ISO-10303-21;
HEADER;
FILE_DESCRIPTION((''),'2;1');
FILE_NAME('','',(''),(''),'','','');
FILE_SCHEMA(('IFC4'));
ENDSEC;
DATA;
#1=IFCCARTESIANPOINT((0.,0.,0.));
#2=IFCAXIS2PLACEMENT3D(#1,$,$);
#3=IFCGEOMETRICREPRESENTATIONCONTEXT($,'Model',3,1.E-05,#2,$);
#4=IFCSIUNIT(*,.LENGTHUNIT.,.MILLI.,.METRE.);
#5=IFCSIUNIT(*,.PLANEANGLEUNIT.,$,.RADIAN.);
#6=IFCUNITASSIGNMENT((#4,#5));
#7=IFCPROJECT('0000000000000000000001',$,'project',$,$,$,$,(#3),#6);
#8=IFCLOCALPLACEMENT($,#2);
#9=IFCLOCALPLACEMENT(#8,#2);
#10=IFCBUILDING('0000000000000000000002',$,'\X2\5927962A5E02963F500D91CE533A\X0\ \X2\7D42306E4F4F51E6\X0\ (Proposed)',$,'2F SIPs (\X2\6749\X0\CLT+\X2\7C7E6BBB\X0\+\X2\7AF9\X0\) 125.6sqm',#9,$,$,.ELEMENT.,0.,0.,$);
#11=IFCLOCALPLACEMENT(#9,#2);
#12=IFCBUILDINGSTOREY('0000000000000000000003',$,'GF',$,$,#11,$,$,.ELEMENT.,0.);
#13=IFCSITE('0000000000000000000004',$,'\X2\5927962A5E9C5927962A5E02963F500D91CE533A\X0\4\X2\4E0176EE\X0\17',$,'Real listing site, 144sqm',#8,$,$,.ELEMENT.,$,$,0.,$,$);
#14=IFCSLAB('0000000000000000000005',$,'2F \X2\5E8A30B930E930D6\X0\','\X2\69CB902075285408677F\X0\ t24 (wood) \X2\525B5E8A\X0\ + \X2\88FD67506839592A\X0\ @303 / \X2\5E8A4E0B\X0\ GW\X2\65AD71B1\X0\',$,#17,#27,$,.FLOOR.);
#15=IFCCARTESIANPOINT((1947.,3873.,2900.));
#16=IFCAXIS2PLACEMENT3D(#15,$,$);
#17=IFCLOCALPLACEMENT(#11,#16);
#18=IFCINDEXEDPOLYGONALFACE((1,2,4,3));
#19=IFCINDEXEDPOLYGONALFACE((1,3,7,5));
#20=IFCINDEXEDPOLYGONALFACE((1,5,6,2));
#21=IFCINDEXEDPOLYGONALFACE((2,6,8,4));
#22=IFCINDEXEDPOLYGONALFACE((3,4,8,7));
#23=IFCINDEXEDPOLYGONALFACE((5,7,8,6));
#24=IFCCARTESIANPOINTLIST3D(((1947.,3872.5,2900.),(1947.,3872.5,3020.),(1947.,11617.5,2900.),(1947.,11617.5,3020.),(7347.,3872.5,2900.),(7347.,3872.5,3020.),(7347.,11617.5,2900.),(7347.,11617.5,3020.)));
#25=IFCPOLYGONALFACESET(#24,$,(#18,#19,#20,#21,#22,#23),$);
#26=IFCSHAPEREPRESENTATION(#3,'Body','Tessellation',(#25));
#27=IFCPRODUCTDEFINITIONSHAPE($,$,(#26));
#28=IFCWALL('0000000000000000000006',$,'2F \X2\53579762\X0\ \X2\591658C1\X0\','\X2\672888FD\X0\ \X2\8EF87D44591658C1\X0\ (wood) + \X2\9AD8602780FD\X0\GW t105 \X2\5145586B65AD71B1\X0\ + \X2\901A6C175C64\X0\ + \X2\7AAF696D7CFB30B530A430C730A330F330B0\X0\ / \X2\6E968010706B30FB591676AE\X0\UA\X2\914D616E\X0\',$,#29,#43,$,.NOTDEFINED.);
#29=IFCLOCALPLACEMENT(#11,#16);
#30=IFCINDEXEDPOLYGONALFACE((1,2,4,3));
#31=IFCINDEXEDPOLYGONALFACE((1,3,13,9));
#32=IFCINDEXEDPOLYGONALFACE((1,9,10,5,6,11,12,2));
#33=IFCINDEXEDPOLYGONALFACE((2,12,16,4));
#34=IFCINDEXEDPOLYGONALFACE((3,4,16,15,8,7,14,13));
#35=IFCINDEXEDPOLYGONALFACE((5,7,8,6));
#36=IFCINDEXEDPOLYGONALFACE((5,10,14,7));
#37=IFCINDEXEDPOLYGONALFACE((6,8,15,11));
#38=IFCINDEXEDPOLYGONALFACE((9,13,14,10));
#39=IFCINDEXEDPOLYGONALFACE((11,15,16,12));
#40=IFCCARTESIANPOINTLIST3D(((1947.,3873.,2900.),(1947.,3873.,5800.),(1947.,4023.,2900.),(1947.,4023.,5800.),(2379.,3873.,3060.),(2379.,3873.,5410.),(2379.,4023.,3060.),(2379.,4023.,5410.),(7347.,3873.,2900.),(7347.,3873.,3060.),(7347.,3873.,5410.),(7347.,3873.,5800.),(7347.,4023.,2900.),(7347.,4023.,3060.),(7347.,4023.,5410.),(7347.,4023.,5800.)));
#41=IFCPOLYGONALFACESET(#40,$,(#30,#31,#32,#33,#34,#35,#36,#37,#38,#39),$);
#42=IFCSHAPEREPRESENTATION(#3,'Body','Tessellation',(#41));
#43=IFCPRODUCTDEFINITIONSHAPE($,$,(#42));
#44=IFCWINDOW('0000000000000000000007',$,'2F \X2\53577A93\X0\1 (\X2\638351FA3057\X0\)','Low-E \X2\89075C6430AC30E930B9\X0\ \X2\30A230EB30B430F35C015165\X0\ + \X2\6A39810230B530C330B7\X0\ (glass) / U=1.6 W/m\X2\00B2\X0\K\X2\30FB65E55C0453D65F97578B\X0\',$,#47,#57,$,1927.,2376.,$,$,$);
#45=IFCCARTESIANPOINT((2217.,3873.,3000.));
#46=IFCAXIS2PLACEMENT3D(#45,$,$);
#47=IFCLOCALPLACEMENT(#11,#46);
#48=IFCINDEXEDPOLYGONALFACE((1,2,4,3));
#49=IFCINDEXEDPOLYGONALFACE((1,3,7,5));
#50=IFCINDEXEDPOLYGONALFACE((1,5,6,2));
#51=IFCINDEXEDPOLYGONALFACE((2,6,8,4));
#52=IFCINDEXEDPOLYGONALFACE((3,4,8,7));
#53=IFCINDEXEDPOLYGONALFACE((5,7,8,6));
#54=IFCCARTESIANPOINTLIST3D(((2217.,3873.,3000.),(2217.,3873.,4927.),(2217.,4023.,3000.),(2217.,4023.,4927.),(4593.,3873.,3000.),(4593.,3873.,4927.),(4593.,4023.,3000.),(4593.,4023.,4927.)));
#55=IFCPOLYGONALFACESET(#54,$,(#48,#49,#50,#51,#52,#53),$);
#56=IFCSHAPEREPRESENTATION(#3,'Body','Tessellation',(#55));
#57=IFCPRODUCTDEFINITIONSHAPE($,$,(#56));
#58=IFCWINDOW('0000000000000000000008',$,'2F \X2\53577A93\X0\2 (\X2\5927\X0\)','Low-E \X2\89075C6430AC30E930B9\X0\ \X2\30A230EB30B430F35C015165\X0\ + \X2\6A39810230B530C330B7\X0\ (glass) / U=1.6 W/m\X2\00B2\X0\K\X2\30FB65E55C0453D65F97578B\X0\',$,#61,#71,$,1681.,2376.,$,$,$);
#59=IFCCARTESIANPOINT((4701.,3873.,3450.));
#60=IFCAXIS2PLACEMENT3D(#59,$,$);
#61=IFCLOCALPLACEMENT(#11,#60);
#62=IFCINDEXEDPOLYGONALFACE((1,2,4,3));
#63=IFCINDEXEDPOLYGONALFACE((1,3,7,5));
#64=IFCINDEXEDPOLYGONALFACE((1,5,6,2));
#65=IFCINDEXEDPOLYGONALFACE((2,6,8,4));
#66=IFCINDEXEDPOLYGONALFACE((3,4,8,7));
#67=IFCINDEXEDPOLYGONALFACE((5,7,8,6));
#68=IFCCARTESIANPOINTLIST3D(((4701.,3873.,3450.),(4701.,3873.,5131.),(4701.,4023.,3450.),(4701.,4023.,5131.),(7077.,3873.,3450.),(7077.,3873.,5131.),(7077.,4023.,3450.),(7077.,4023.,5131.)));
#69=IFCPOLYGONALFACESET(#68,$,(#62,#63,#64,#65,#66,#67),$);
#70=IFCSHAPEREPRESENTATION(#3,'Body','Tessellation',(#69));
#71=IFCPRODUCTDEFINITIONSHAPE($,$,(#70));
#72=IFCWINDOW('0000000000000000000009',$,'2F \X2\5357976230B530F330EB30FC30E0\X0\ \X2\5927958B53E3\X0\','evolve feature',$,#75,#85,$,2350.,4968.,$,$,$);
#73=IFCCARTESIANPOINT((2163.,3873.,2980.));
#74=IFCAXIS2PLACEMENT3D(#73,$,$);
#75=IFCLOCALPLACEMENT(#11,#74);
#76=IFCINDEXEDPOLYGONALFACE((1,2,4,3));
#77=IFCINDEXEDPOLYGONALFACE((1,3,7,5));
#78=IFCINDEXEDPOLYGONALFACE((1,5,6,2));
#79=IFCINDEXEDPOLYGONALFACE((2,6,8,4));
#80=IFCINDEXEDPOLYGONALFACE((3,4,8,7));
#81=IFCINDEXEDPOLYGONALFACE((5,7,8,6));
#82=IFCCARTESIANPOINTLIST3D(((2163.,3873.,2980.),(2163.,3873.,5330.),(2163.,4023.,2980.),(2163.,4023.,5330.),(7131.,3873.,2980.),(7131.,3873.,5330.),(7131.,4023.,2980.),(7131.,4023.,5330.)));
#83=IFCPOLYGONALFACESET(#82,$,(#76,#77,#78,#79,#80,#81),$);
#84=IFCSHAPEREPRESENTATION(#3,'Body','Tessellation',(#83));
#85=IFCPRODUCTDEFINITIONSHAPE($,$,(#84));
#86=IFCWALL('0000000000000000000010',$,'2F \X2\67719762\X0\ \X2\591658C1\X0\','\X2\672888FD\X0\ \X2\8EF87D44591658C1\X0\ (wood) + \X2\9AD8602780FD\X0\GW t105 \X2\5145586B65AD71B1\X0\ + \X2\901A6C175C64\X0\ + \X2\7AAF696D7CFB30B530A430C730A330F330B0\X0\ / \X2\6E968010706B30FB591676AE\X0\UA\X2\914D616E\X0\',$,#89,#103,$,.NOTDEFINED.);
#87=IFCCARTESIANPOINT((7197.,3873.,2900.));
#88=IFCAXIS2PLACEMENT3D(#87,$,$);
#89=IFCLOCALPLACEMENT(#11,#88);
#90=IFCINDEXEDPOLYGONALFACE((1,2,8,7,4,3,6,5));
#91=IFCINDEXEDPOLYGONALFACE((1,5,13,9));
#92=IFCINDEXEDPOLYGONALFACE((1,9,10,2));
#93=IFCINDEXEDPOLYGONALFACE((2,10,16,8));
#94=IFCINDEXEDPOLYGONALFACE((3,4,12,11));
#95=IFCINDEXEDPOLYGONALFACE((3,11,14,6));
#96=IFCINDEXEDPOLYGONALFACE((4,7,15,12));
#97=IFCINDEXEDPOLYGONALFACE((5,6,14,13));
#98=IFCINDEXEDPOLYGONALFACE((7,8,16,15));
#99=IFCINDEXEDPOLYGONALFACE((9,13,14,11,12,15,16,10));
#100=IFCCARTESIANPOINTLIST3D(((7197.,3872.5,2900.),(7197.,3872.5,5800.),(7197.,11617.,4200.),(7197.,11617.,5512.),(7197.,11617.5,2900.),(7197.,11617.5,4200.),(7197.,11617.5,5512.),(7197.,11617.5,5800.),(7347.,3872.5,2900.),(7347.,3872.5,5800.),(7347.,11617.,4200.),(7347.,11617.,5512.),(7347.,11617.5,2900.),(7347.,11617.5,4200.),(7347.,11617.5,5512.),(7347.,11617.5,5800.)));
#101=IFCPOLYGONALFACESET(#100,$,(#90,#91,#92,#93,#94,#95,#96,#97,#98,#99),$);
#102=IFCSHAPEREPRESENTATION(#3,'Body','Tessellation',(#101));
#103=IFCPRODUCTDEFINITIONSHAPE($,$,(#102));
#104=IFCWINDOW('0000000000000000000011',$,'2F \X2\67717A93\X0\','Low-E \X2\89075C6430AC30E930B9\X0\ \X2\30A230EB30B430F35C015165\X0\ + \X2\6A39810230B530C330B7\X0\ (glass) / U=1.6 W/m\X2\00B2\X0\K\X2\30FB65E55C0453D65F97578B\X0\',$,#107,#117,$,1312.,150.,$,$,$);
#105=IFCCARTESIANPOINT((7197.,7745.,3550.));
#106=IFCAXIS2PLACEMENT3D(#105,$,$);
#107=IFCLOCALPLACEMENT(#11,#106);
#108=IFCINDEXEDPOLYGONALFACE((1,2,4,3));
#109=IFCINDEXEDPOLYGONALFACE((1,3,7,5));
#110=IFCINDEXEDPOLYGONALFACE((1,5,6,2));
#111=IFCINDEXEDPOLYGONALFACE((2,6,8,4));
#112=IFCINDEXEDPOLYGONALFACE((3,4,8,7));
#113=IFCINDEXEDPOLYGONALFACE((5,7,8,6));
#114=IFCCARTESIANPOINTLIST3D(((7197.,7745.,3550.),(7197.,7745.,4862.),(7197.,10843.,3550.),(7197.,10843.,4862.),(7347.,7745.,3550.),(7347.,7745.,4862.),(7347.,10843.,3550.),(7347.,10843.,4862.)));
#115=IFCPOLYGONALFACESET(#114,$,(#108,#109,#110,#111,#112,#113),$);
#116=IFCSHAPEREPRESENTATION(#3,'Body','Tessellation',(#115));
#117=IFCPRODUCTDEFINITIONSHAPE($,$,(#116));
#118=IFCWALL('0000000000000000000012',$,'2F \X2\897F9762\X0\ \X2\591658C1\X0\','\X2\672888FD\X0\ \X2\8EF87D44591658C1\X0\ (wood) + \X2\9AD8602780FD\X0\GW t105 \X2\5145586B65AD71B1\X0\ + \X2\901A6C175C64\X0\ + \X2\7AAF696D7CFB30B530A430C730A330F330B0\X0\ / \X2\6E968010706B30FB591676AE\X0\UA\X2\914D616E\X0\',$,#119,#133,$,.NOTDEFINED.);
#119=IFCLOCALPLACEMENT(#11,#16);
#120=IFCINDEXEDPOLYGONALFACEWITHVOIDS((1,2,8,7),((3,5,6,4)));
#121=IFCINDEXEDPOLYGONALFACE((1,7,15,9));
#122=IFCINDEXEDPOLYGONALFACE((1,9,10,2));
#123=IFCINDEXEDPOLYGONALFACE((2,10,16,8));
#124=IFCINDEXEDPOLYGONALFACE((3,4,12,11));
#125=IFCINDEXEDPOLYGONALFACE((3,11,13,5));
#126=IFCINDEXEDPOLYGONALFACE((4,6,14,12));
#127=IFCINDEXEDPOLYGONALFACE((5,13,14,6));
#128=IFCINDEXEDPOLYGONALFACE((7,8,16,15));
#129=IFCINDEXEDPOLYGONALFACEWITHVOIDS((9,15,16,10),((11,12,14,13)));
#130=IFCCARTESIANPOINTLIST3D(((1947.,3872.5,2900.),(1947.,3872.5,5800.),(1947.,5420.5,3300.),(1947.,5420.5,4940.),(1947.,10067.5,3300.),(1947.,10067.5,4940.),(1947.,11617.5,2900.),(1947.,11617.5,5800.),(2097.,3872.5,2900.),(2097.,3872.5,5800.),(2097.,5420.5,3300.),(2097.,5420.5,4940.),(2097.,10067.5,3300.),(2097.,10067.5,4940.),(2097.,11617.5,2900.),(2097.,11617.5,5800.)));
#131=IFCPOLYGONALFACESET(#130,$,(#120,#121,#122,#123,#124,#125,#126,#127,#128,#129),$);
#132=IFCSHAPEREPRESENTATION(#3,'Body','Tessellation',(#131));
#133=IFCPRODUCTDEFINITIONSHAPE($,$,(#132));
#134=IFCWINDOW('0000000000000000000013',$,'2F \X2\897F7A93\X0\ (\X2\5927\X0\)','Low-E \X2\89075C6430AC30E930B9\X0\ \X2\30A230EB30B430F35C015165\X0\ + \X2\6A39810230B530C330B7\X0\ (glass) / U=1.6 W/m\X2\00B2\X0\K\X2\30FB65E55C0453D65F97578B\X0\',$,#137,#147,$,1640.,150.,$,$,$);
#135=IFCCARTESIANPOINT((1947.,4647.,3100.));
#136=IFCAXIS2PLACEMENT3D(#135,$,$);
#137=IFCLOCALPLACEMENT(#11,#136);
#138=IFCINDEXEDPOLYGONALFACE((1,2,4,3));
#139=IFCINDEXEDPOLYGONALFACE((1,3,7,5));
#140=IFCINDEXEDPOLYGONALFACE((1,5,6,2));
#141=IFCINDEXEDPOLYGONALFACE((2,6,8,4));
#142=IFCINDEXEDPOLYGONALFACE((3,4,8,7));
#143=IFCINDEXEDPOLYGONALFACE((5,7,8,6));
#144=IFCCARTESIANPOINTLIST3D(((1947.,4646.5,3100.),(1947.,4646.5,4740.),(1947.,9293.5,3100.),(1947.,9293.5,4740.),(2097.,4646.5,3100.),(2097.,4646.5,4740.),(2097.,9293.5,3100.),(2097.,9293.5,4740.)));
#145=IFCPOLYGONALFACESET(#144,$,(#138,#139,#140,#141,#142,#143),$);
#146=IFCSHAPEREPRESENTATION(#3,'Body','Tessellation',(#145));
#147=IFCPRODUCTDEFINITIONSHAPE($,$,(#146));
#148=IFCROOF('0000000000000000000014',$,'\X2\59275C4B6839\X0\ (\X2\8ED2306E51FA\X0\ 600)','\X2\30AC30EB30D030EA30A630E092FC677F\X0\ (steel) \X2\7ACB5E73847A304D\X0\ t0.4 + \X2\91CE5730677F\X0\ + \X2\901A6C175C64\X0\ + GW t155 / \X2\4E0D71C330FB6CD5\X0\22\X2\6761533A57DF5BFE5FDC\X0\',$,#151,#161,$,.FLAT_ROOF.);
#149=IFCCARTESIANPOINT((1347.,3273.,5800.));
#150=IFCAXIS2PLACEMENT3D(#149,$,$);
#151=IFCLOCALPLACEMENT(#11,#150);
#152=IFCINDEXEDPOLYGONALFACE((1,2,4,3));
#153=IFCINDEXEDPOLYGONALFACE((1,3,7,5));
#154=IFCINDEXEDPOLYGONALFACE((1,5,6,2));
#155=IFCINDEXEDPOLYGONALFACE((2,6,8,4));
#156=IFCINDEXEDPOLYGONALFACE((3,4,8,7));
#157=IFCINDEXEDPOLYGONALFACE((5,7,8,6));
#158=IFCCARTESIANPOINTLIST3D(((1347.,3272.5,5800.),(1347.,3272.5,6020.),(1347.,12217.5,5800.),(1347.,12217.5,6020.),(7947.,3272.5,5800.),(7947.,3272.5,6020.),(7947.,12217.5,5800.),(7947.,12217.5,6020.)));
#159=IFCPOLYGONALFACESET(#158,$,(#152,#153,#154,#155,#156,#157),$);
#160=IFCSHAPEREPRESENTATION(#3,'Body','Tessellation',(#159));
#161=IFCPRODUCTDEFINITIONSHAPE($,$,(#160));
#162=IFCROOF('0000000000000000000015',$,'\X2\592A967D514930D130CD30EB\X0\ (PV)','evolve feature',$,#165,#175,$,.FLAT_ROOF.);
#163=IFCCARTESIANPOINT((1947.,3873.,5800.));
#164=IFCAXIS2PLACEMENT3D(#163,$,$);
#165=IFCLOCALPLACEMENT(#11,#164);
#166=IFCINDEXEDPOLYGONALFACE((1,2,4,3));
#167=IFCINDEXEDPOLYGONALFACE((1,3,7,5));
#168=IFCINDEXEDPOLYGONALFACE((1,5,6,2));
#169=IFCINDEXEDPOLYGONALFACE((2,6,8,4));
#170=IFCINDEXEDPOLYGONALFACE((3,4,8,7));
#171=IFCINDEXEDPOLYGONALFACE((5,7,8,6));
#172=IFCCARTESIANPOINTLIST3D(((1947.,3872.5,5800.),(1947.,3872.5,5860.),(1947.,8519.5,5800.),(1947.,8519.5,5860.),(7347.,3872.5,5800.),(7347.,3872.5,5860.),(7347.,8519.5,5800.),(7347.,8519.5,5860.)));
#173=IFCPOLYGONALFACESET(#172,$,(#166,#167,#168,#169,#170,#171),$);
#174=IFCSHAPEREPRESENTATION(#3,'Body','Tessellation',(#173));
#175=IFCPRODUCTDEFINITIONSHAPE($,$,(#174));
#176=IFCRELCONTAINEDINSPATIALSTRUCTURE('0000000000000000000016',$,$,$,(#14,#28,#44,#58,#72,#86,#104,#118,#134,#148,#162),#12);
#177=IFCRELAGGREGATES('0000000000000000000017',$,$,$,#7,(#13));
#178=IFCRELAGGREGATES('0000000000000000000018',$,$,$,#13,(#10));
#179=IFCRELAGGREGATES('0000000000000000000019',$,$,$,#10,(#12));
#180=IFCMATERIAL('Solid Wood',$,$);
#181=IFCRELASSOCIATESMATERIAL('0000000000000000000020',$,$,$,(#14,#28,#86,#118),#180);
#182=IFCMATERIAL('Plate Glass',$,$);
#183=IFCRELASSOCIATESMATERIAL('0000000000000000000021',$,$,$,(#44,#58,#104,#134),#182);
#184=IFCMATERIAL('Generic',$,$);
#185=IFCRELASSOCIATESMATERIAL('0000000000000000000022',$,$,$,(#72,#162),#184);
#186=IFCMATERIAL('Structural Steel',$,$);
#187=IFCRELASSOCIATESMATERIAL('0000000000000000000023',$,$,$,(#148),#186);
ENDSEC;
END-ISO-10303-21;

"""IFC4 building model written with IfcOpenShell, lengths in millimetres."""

from ifc_helpers import new_model, si_unit, frame, frame_2d, origin, place, context, project, spatial, rectangle, extrude, material, element, fill, save


model = new_model("IFC4")

# Units and contexts
model_context = context("Model", 3, precision=1e-05, world=origin())
ifc_project = project(units=[si_unit("LENGTHUNIT", "METRE", prefix="MILLI"), si_unit("PLANEANGLEUNIT", "RADIAN")], contexts=[model_context])

# Site, building, storey
site_placement = place(None, origin())
site = spatial("IfcSite", under=ifc_project, at=site_placement, Name="大阪府大阪市阿倍野区4丁目17", ObjectType="Real listing site, 144sqm", CompositionType="ELEMENT", RefElevation=0.0)
building_placement = place(site_placement, origin())
building = spatial("IfcBuilding", under=site, at=building_placement, Name="大阪市阿倍野区 終の住処 (Proposed)", ObjectType="2F SIPs (杉CLT+籾殻+竹) 125.6sqm", CompositionType="ELEMENT", ElevationOfRefHeight=0.0, ElevationOfTerrain=0.0)
storey_placement = place(building_placement, origin())
storey = spatial("IfcBuildingStorey", under=building, at=storey_placement, Name="GF", CompositionType="ELEMENT", Elevation=0.0)

# Slab
ifc_material_1 = material(Name="Solid Wood")
slab_placement = place(storey_placement, frame((1947.0, 3873.0, 2900.0)))
element("IfcSlab", 1, at=slab_placement, inside=storey, material=ifc_material_1, Name="2F 床スラブ", Description="構造用合板 t24 (wood) 剛床 + 製材根太 @303 / 床下 GW断熱", PredefinedType="FLOOR", context=model_context, shape_type="SweptSolid", body=[
    extrude(rectangle(XDim=5400.0, YDim=7745.0, at=frame_2d((2700.0, 3872.0))), frame((1947.0, 3873.0, 2900.0)), (0.0, 0.0, 1.0), 120.0),
])

# Wall, openings, windows
wall_1_placement = place(storey_placement, frame((1947.0, 3873.0, 2900.0)))
wall_1 = element("IfcWall", 2, at=wall_1_placement, inside=storey, material=ifc_material_1, Name="2F 南面 外壁", Description="木製 軸組外壁 (wood) + 高性能GW t105 充填断熱 + 通気層 + 窯業系サイディング / 準耐火・外皮UA配慮", PredefinedType="NOTDEFINED", context=model_context, shape_type="SweptSolid", body=[
    extrude(rectangle(XDim=5400.0, YDim=150.0, at=frame_2d((2700.0, 75.0))), frame((1947.0, 3873.0, 2900.0)), (0.0, 0.0, 1.0), 2900.0),
])
opening_1_placement = place(storey_placement, frame((2217.0, 3873.0, 3000.0)))
opening_1 = element("IfcOpeningElement", 3, at=opening_1_placement, cuts=wall_1, PredefinedType="NOTDEFINED", context=model_context, shape_type="SweptSolid", body=[
    extrude(rectangle(XDim=2376.0, YDim=150.0, at=frame_2d((1188.0, 75.0))), frame((2217.0, 3873.0, 3000.0)), (0.0, 0.0, 1.0), 1927.0),
])
opening_2_placement = place(storey_placement, frame((4701.0, 3873.0, 3450.0)))
opening_2 = element("IfcOpeningElement", 4, at=opening_2_placement, cuts=wall_1, PredefinedType="NOTDEFINED", context=model_context, shape_type="SweptSolid", body=[
    extrude(rectangle(XDim=2376.0, YDim=150.0, at=frame_2d((1188.0, 75.0))), frame((4701.0, 3873.0, 3450.0)), (0.0, 0.0, 1.0), 1681.0),
])
opening_3_placement = place(storey_placement, frame((2163.0, 3873.0, 2980.0)))
opening_3 = element("IfcOpeningElement", 5, at=opening_3_placement, cuts=wall_1, PredefinedType="NOTDEFINED", context=model_context, shape_type="SweptSolid", body=[
    extrude(rectangle(XDim=4968.0, YDim=150.0, at=frame_2d((2484.0, 75.0))), frame((2163.0, 3873.0, 2980.0)), (0.0, 0.0, 1.0), 2350.0),
])
ifc_material_2 = material(Name="Plate Glass")
window_1_placement = place(storey_placement, frame((2217.0, 3873.0, 3000.0)))
window_1 = element("IfcWindow", 6, at=window_1_placement, inside=storey, material=ifc_material_2, Name="2F 南窓1 (掃出し)", Description="Low-E 複層ガラス アルゴン封入 + 樹脂サッシ (glass) / U=1.6 W/m²K・日射取得型", OverallHeight=1927.0, OverallWidth=2376.0, context=model_context, shape_type="SweptSolid", body=[
    extrude(rectangle(XDim=2376.0, YDim=150.0, at=frame_2d((1188.0, 75.0))), frame((2217.0, 3873.0, 3000.0)), (0.0, 0.0, 1.0), 1927.0),
])
fill(opening_1, window_1)
window_2_placement = place(storey_placement, frame((4701.0, 3873.0, 3450.0)))
window_2 = element("IfcWindow", 7, at=window_2_placement, inside=storey, material=ifc_material_2, Name="2F 南窓2 (大)", Description="Low-E 複層ガラス アルゴン封入 + 樹脂サッシ (glass) / U=1.6 W/m²K・日射取得型", OverallHeight=1681.0, OverallWidth=2376.0, context=model_context, shape_type="SweptSolid", body=[
    extrude(rectangle(XDim=2376.0, YDim=150.0, at=frame_2d((1188.0, 75.0))), frame((4701.0, 3873.0, 3450.0)), (0.0, 0.0, 1.0), 1681.0),
])
fill(opening_2, window_2)
ifc_material_3 = material(Name="Generic")
window_3_placement = place(storey_placement, frame((2163.0, 3873.0, 2980.0)))
window_3 = element("IfcWindow", 8, at=window_3_placement, inside=storey, material=ifc_material_3, Name="2F 南面サンルーム 大開口", Description="evolve feature", OverallHeight=2350.0, OverallWidth=4968.0, context=model_context, shape_type="SweptSolid", body=[
    extrude(rectangle(XDim=4968.0, YDim=150.0, at=frame_2d((2484.0, 75.0))), frame((2163.0, 3873.0, 2980.0)), (0.0, 0.0, 1.0), 2350.0),
])
fill(opening_3, window_3)

# Walls, openings, windows
wall_2_placement = place(storey_placement, frame((7197.0, 3873.0, 2900.0)))
wall_2 = element("IfcWall", 9, at=wall_2_placement, inside=storey, material=ifc_material_1, Name="2F 東面 外壁", Description="木製 軸組外壁 (wood) + 高性能GW t105 充填断熱 + 通気層 + 窯業系サイディング / 準耐火・外皮UA配慮", PredefinedType="NOTDEFINED", context=model_context, shape_type="SweptSolid", body=[
    extrude(rectangle(XDim=150.0, YDim=7745.0, at=frame_2d((75.0, 3872.0))), frame((7197.0, 3873.0, 2900.0)), (0.0, 0.0, 1.0), 2900.0),
])
opening_4_placement = place(storey_placement, frame((7197.0, 7745.0, 3550.0)))
opening_4 = element("IfcOpeningElement", 10, at=opening_4_placement, cuts=wall_2, PredefinedType="NOTDEFINED", context=model_context, shape_type="SweptSolid", body=[
    extrude(rectangle(XDim=150.0, YDim=3098.0, at=frame_2d((75.0, 1549.0))), frame((7197.0, 7745.0, 3550.0)), (0.0, 0.0, 1.0), 1312.0),
])
window_4_placement = place(storey_placement, frame((7197.0, 7745.0, 3550.0)))
window_4 = element("IfcWindow", 11, at=window_4_placement, inside=storey, material=ifc_material_2, Name="2F 東窓", Description="Low-E 複層ガラス アルゴン封入 + 樹脂サッシ (glass) / U=1.6 W/m²K・日射取得型", OverallHeight=1312.0, OverallWidth=150.0, context=model_context, shape_type="SweptSolid", body=[
    extrude(rectangle(XDim=150.0, YDim=3098.0, at=frame_2d((75.0, 1549.0))), frame((7197.0, 7745.0, 3550.0)), (0.0, 0.0, 1.0), 1312.0),
])
fill(opening_4, window_4)
wall_3_placement = place(storey_placement, frame((1947.0, 3873.0, 2900.0)))
wall_3 = element("IfcWall", 12, at=wall_3_placement, inside=storey, material=ifc_material_1, Name="2F 西面 外壁", Description="木製 軸組外壁 (wood) + 高性能GW t105 充填断熱 + 通気層 + 窯業系サイディング / 準耐火・外皮UA配慮", PredefinedType="NOTDEFINED", context=model_context, shape_type="SweptSolid", body=[
    extrude(rectangle(XDim=150.0, YDim=7745.0, at=frame_2d((75.0, 3872.0))), frame((1947.0, 3873.0, 2900.0)), (0.0, 0.0, 1.0), 2900.0),
])
opening_5_placement = place(storey_placement, frame((1947.0, 4647.0, 3100.0)))
opening_5 = element("IfcOpeningElement", 13, at=opening_5_placement, cuts=wall_3, PredefinedType="NOTDEFINED", context=model_context, shape_type="SweptSolid", body=[
    extrude(rectangle(XDim=150.0, YDim=4647.0, at=frame_2d((75.0, 2323.0))), frame((1947.0, 4647.0, 3100.0)), (0.0, 0.0, 1.0), 1640.0),
])
window_5_placement = place(storey_placement, frame((1947.0, 4647.0, 3100.0)))
window_5 = element("IfcWindow", 14, at=window_5_placement, inside=storey, material=ifc_material_2, Name="2F 西窓 (大)", Description="Low-E 複層ガラス アルゴン封入 + 樹脂サッシ (glass) / U=1.6 W/m²K・日射取得型", OverallHeight=1640.0, OverallWidth=150.0, context=model_context, shape_type="SweptSolid", body=[
    extrude(rectangle(XDim=150.0, YDim=4647.0, at=frame_2d((75.0, 2323.0))), frame((1947.0, 4647.0, 3100.0)), (0.0, 0.0, 1.0), 1640.0),
])
fill(opening_5, window_5)

# Roofs
ifc_material_4 = material(Name="Structural Steel")
roof_1_placement = place(storey_placement, frame((1347.0, 3273.0, 5800.0)))
element("IfcRoof", 15, at=roof_1_placement, inside=storey, material=ifc_material_4, Name="大屋根 (軒の出 600)", Description="ガルバリウム鋼板 (steel) 立平葺き t0.4 + 野地板 + 通気層 + GW t155 / 不燃・法22条区域対応", PredefinedType="FLAT_ROOF", context=model_context, shape_type="SweptSolid", body=[
    extrude(rectangle(XDim=6600.0, YDim=8945.0, at=frame_2d((3300.0, 4472.0))), frame((1347.0, 3273.0, 5800.0)), (0.0, 0.0, 1.0), 220.0),
])
roof_2_placement = place(storey_placement, frame((1947.0, 3873.0, 5800.0)))
element("IfcRoof", 16, at=roof_2_placement, inside=storey, material=ifc_material_3, Name="太陽光パネル (PV)", Description="evolve feature", PredefinedType="FLAT_ROOF", context=model_context, shape_type="SweptSolid", body=[
    extrude(rectangle(XDim=5400.0, YDim=4647.0, at=frame_2d((2700.0, 2323.0))), frame((1947.0, 3873.0, 5800.0)), (0.0, 0.0, 1.0), 60.0),
])

save(model, "model.ifc")
